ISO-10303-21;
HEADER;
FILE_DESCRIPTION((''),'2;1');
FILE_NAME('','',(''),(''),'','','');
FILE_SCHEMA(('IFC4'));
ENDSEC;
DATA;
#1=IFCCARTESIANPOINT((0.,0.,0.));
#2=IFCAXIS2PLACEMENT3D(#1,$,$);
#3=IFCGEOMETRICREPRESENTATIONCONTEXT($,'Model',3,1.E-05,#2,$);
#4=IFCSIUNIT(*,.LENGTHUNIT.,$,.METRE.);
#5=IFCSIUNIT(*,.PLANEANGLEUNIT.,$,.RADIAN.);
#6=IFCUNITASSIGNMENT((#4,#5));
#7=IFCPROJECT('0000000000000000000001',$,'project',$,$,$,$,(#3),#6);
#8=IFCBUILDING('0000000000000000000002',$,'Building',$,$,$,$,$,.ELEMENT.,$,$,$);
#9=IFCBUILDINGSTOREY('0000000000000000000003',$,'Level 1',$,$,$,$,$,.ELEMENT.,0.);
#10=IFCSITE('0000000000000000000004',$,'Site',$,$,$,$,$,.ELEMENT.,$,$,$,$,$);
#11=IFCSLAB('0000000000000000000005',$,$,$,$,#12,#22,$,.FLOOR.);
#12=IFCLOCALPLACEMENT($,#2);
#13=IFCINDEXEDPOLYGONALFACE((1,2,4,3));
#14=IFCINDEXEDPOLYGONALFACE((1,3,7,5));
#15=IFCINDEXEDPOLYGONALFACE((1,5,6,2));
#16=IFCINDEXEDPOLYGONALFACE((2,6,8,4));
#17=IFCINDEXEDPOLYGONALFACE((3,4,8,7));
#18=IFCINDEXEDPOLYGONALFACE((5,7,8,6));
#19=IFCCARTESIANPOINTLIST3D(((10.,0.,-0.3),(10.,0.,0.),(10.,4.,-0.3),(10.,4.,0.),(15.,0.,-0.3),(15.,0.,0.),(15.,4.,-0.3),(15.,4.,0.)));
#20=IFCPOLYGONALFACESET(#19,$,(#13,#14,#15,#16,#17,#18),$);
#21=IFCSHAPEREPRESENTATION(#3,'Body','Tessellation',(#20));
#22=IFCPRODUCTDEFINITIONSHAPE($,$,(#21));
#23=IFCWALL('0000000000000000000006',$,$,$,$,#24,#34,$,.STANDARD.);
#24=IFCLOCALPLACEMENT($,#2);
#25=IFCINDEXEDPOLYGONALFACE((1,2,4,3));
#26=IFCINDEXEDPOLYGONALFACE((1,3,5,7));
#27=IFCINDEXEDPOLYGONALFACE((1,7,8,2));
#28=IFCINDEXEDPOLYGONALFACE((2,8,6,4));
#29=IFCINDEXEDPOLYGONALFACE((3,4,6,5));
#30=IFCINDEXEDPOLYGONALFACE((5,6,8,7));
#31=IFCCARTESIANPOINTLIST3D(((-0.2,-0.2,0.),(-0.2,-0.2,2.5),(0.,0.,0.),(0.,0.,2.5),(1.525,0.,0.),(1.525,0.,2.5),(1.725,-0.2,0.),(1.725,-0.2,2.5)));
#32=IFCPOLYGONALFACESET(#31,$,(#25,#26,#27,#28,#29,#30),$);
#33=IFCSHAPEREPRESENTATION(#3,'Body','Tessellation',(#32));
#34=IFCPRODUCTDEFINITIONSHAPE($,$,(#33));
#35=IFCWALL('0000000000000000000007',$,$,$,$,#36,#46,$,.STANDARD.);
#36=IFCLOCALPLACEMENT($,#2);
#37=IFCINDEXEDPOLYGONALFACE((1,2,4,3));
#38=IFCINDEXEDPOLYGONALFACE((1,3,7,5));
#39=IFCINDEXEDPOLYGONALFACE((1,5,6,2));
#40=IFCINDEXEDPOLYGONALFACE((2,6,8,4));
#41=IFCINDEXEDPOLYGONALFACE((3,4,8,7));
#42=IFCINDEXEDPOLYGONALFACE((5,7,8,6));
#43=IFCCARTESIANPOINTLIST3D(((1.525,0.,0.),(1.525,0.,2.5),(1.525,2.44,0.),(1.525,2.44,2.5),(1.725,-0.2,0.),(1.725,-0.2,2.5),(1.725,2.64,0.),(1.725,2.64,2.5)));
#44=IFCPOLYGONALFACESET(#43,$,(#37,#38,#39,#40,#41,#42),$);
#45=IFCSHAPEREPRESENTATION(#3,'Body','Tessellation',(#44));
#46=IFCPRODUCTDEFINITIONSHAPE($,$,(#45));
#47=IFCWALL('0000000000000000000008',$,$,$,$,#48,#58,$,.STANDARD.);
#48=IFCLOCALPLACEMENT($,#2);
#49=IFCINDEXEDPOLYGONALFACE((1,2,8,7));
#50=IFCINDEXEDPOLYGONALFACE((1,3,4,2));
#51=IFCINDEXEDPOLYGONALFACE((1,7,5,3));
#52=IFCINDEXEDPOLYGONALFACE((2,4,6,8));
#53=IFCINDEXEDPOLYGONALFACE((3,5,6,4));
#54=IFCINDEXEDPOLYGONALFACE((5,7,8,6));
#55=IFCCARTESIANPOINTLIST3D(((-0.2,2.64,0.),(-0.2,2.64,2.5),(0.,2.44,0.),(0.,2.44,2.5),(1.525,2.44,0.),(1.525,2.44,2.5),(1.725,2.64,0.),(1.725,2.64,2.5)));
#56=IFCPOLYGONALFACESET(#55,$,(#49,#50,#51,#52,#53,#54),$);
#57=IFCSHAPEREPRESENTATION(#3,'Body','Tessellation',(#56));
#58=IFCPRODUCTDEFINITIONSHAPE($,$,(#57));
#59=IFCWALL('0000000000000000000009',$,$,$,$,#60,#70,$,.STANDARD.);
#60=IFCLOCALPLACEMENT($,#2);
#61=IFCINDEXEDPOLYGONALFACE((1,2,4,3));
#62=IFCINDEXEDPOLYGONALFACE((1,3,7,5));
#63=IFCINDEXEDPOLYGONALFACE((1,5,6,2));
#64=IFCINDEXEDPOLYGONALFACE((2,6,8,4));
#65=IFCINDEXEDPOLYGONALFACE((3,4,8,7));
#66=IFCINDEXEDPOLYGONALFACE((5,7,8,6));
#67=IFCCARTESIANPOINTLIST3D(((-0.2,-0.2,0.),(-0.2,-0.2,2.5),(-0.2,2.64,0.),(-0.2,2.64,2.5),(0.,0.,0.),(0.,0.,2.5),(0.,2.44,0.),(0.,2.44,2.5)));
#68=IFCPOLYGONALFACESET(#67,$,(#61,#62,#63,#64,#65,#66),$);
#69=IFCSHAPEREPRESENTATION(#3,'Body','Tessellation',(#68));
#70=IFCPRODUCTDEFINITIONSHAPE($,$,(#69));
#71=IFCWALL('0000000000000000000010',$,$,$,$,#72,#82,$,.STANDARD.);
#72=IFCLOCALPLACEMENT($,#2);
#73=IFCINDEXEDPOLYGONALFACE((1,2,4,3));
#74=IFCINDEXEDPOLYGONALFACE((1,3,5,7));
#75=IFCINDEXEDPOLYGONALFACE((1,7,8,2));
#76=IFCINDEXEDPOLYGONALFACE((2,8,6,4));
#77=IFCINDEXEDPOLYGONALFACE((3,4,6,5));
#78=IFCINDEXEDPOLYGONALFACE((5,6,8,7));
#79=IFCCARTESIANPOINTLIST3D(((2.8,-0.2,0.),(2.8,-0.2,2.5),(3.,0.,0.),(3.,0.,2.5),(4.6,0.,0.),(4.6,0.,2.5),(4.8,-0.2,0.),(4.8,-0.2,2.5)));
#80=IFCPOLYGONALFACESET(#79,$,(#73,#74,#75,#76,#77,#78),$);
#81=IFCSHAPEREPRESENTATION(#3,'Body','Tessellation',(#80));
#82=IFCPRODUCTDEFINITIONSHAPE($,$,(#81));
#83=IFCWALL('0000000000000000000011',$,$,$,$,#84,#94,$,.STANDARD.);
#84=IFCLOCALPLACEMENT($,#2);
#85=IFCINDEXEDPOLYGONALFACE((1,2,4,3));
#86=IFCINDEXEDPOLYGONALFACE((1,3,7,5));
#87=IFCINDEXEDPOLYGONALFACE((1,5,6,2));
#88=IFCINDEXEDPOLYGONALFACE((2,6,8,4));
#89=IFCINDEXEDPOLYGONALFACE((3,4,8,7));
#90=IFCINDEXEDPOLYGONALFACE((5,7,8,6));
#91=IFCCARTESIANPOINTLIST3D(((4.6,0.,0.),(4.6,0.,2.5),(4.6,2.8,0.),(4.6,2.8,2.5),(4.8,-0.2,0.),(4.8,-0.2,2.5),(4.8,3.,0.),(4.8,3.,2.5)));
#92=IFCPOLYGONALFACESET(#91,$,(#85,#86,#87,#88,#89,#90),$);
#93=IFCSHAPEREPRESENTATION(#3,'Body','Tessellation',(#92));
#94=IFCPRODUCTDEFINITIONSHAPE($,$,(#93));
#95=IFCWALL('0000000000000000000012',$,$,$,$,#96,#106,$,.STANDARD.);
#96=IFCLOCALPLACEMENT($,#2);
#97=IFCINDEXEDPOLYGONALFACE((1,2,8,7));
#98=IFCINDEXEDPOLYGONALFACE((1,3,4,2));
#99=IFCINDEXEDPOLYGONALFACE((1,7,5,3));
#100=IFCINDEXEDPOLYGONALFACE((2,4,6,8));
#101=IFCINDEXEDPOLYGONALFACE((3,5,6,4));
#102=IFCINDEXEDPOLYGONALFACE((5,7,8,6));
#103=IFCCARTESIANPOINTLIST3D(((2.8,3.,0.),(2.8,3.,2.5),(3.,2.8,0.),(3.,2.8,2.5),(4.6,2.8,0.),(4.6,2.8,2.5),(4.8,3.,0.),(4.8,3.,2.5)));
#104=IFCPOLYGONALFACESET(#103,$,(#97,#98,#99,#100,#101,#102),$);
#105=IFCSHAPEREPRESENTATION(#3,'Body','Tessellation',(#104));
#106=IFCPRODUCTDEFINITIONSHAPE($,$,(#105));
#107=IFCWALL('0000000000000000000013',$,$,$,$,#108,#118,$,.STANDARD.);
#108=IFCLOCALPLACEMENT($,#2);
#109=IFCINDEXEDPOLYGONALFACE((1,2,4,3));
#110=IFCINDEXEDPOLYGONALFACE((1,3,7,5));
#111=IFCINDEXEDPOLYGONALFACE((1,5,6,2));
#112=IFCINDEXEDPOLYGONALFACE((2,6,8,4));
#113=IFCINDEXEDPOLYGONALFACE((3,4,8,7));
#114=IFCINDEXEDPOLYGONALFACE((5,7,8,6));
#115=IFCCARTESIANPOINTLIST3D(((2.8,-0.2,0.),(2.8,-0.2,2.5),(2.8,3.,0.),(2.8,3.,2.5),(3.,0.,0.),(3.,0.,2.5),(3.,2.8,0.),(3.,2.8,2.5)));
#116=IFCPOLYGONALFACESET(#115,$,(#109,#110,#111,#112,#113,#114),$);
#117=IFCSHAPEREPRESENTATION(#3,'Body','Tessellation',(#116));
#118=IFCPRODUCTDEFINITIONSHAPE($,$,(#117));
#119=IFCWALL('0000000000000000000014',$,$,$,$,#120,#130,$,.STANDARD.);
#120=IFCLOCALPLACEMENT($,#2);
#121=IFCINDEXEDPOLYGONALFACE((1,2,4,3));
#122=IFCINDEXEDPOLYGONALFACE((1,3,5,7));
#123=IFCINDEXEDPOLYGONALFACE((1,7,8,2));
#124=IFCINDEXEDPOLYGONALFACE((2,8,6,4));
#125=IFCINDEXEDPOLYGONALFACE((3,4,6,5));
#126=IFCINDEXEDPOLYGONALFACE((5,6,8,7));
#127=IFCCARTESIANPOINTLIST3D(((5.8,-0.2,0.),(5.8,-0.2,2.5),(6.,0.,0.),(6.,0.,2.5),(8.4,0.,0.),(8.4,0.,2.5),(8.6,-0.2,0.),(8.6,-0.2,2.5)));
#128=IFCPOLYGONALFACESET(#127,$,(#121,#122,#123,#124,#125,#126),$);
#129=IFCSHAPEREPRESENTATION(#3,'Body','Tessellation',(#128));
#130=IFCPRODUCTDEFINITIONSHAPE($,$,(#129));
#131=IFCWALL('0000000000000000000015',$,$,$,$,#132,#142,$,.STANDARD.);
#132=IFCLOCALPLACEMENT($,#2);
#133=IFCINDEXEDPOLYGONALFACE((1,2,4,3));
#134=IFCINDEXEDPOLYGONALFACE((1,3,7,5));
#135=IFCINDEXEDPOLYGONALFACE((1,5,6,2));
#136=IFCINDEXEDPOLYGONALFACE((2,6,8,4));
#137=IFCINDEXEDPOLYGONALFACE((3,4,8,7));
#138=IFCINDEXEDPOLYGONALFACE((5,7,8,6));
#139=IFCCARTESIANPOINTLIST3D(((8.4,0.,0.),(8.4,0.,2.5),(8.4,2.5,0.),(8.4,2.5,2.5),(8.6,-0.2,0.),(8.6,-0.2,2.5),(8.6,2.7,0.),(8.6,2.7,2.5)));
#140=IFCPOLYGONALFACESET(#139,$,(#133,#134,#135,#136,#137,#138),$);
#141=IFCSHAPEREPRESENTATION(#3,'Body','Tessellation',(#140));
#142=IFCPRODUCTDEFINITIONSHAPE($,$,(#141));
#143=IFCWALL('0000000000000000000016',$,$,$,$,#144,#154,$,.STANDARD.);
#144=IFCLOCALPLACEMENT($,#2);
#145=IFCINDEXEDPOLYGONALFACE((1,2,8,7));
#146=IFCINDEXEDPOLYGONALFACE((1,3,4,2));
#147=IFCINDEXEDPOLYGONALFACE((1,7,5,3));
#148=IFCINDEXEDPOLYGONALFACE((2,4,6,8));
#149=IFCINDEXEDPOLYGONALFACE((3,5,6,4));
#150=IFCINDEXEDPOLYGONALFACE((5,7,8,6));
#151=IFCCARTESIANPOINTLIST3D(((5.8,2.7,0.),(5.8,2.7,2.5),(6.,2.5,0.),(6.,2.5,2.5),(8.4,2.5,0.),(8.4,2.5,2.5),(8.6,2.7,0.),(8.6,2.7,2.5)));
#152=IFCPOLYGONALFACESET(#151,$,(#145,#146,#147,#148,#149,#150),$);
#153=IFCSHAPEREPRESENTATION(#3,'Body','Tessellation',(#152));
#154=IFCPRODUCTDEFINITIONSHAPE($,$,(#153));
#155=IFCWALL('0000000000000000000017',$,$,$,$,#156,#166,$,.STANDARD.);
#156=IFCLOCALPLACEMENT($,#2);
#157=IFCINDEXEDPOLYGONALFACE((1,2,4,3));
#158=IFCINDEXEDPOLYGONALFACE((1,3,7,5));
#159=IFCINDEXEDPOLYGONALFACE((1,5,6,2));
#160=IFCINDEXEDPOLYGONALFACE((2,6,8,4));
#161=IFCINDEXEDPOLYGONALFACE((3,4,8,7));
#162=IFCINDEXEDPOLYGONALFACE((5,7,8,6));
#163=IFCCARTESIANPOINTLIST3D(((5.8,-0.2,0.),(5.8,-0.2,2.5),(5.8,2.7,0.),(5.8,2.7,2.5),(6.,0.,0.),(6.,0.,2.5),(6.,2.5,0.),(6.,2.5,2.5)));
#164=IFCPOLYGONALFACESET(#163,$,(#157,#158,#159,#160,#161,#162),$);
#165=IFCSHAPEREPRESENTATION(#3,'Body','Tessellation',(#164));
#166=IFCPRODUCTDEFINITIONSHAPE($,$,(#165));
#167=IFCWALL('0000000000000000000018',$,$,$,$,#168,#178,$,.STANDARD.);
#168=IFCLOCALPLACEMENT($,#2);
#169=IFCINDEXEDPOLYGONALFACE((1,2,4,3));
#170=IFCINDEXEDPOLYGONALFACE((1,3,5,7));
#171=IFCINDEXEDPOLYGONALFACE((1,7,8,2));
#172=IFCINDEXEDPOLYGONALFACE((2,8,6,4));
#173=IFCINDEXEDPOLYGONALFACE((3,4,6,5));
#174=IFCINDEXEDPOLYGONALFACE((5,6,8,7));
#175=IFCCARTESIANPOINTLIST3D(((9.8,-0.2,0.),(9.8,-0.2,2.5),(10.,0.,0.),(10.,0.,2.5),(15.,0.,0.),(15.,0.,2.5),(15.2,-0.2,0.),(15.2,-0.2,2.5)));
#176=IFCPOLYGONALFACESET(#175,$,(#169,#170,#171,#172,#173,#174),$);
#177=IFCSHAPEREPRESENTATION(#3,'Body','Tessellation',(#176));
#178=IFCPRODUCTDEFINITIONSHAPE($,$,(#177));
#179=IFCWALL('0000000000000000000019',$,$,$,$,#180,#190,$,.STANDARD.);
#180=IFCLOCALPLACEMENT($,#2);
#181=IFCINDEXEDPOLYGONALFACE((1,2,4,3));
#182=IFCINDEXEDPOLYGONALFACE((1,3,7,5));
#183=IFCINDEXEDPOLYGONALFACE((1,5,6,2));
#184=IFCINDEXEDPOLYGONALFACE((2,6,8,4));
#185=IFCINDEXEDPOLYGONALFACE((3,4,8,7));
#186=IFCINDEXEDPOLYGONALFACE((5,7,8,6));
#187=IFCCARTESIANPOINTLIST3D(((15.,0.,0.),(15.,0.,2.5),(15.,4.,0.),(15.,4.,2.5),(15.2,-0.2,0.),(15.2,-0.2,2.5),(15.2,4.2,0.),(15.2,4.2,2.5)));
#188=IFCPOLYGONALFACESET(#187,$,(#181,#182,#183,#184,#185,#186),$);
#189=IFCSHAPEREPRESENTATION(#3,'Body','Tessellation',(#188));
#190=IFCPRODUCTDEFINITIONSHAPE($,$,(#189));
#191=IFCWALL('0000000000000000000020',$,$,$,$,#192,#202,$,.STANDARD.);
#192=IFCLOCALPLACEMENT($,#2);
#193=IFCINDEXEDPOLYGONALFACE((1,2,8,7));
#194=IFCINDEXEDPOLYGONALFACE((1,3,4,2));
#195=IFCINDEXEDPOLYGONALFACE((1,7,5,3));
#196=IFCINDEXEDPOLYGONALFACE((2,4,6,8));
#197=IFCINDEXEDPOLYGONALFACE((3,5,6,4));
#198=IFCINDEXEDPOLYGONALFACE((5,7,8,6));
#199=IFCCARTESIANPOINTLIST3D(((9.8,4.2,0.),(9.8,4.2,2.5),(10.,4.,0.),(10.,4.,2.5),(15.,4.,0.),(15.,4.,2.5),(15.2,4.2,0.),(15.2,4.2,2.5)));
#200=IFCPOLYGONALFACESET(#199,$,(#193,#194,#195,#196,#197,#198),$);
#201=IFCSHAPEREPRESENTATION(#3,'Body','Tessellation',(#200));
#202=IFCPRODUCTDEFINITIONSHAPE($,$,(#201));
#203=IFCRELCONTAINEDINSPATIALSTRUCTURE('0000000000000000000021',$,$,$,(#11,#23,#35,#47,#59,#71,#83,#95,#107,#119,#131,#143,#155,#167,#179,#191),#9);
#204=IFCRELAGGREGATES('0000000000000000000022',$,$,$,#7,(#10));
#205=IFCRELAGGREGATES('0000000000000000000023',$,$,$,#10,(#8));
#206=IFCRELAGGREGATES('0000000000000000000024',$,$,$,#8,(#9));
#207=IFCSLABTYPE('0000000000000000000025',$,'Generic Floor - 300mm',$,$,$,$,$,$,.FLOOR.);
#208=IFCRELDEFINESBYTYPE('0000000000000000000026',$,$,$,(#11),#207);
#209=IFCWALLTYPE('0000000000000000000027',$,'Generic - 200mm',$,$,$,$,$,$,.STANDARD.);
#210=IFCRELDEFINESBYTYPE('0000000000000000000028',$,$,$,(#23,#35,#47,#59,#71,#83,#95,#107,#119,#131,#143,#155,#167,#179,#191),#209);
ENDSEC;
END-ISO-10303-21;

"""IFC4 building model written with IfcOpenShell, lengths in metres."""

from ifc_helpers import new_model, si_unit, frame, origin, place, context, project, spatial, polyline, outline, extrude, type_object, element, save


model = new_model("IFC4")

# Units and contexts
model_context = context("Model", 3, precision=1e-05, world=origin())
ifc_project = project(units=[si_unit("LENGTHUNIT", "METRE"), si_unit("PLANEANGLEUNIT", "RADIAN")], contexts=[model_context])

# Site, building, storey
site = spatial("IfcSite", under=ifc_project, Name="Site", CompositionType="ELEMENT")
building = spatial("IfcBuilding", under=site, Name="Building", CompositionType="ELEMENT")
storey = spatial("IfcBuildingStorey", under=building, Name="Level 1", CompositionType="ELEMENT", Elevation=0.0)

# Slab
slab_type = type_object("IfcSlabType", Name="Generic Floor - 300mm", PredefinedType="FLOOR")
slab_placement = place(None, origin())
element("IfcSlab", 1, at=slab_placement, inside=storey, type_object=slab_type, PredefinedType="FLOOR", context=model_context, shape_type="SweptSolid", body=[
    extrude(outline(polyline([(10.0, 0.0), (15.0, 0.0), (15.0, 4.0), (10.0, 4.0), (10.0, 0.0)])), origin(), (0.0, 0.0, -1.0), 0.3),
])

# Walls
wall_type_1 = type_object("IfcWallType", Name="Generic - 200mm", PredefinedType="STANDARD")
wall_1_placement = place(None, frame((-0.1, -0.1, 0.0), z_axis=(0.0, 0.0, 1.0), x_axis=(1.0, 0.0, 0.0)))
element("IfcWall", 2, at=wall_1_placement, inside=storey, type_object=wall_type_1, PredefinedType="STANDARD", context=model_context, shape_type="SweptSolid", body=[
    extrude(outline(polyline([(-0.1, -0.1), (1.825, -0.1), (1.625, 0.1), (0.1, 0.1), (-0.1, -0.1)])), origin(), (0.0, 0.0, 1.0), 2.5),
])
wall_2_placement = place(None, frame((1.625, -0.1, 0.0), z_axis=(0.0, 0.0, 1.0), x_axis=(0.0, 1.0, 0.0)))
element("IfcWall", 3, at=wall_2_placement, inside=storey, type_object=wall_type_1, PredefinedType="STANDARD", context=model_context, shape_type="SweptSolid", body=[
    extrude(outline(polyline([(-0.1, -0.1), (2.74, -0.1), (2.54, 0.1), (0.1, 0.1), (-0.1, -0.1)])), origin(), (0.0, 0.0, 1.0), 2.5),
])
wall_3_placement = place(None, frame((1.625, 2.54, 0.0), z_axis=(0.0, 0.0, 1.0), x_axis=(-1.0, 0.0, 0.0)))
element("IfcWall", 4, at=wall_3_placement, inside=storey, type_object=wall_type_1, PredefinedType="STANDARD", context=model_context, shape_type="SweptSolid", body=[
    extrude(outline(polyline([(-0.1, -0.1), (1.825, -0.1), (1.625, 0.1), (0.1, 0.1), (-0.1, -0.1)])), origin(), (0.0, 0.0, 1.0), 2.5),
])
wall_4_placement = place(None, frame((-0.1, 2.54, 0.0), z_axis=(0.0, 0.0, 1.0), x_axis=(0.0, -1.0, 0.0)))
element("IfcWall", 5, at=wall_4_placement, inside=storey, type_object=wall_type_1, PredefinedType="STANDARD", context=model_context, shape_type="SweptSolid", body=[
    extrude(outline(polyline([(-0.1, -0.1), (2.74, -0.1), (2.54, 0.1), (0.1, 0.1), (-0.1, -0.1)])), origin(), (0.0, 0.0, 1.0), 2.5),
])
wall_5_placement = place(None, frame((2.9, -0.1, 0.0), z_axis=(0.0, 0.0, 1.0), x_axis=(1.0, 0.0, 0.0)))
element("IfcWall", 6, at=wall_5_placement, inside=storey, type_object=wall_type_1, PredefinedType="STANDARD", context=model_context, shape_type="SweptSolid", body=[
    extrude(outline(polyline([(-0.1, -0.1), (1.9, -0.1), (1.7, 0.1), (0.1, 0.1), (-0.1, -0.1)])), origin(), (0.0, 0.0, 1.0), 2.5),
])
wall_6_placement = place(None, frame((4.7, -0.1, 0.0), z_axis=(0.0, 0.0, 1.0), x_axis=(0.0, 1.0, 0.0)))
element("IfcWall", 7, at=wall_6_placement, inside=storey, type_object=wall_type_1, PredefinedType="STANDARD", context=model_context, shape_type="SweptSolid", body=[
    extrude(outline(polyline([(-0.1, -0.1), (3.1, -0.1), (2.9, 0.1), (0.1, 0.1), (-0.1, -0.1)])), origin(), (0.0, 0.0, 1.0), 2.5),
])
wall_7_placement = place(None, frame((4.7, 2.9, 0.0), z_axis=(0.0, 0.0, 1.0), x_axis=(-1.0, 0.0, 0.0)))
element("IfcWall", 8, at=wall_7_placement, inside=storey, type_object=wall_type_1, PredefinedType="STANDARD", context=model_context, shape_type="SweptSolid", body=[
    extrude(outline(polyline([(-0.1, -0.1), (1.9, -0.1), (1.7, 0.1), (0.1, 0.1), (-0.1, -0.1)])), origin(), (0.0, 0.0, 1.0), 2.5),
])
wall_8_placement = place(None, frame((2.9, 2.9, 0.0), z_axis=(0.0, 0.0, 1.0), x_axis=(0.0, -1.0, 0.0)))
element("IfcWall", 9, at=wall_8_placement, inside=storey, type_object=wall_type_1, PredefinedType="STANDARD", context=model_context, shape_type="SweptSolid", body=[
    extrude(outline(polyline([(-0.1, -0.1), (3.1, -0.1), (2.9, 0.1), (0.1, 0.1), (-0.1, -0.1)])), origin(), (0.0, 0.0, 1.0), 2.5),
])
wall_9_placement = place(None, frame((5.9, -0.1, 0.0), z_axis=(0.0, 0.0, 1.0), x_axis=(1.0, 0.0, 0.0)))
element("IfcWall", 10, at=wall_9_placement, inside=storey, type_object=wall_type_1, PredefinedType="STANDARD", context=model_context, shape_type="SweptSolid", body=[
    extrude(outline(polyline([(-0.1, -0.1), (2.7, -0.1), (2.5, 0.1), (0.1, 0.1), (-0.1, -0.1)])), origin(), (0.0, 0.0, 1.0), 2.5),
])
wall_10_placement = place(None, frame((8.5, -0.1, 0.0), z_axis=(0.0, 0.0, 1.0), x_axis=(0.0, 1.0, 0.0)))
element("IfcWall", 11, at=wall_10_placement, inside=storey, type_object=wall_type_1, PredefinedType="STANDARD", context=model_context, shape_type="SweptSolid", body=[
    extrude(outline(polyline([(-0.1, -0.1), (2.8, -0.1), (2.6, 0.1), (0.1, 0.1), (-0.1, -0.1)])), origin(), (0.0, 0.0, 1.0), 2.5),
])
wall_11_placement = place(None, frame((8.5, 2.6, 0.0), z_axis=(0.0, 0.0, 1.0), x_axis=(-1.0, 0.0, 0.0)))
element("IfcWall", 12, at=wall_11_placement, inside=storey, type_object=wall_type_1, PredefinedType="STANDARD", context=model_context, shape_type="SweptSolid", body=[
    extrude(outline(polyline([(-0.1, -0.1), (2.7, -0.1), (2.5, 0.1), (0.1, 0.1), (-0.1, -0.1)])), origin(), (0.0, 0.0, 1.0), 2.5),
])
wall_12_placement = place(None, frame((5.9, 2.6, 0.0), z_axis=(0.0, 0.0, 1.0), x_axis=(0.0, -1.0, 0.0)))
element("IfcWall", 13, at=wall_12_placement, inside=storey, type_object=wall_type_1, PredefinedType="STANDARD", context=model_context, shape_type="SweptSolid", body=[
    extrude(outline(polyline([(-0.1, -0.1), (2.8, -0.1), (2.6, 0.1), (0.1, 0.1), (-0.1, -0.1)])), origin(), (0.0, 0.0, 1.0), 2.5),
])
wall_13_placement = place(None, frame((9.9, -0.1, 0.0), z_axis=(0.0, 0.0, 1.0), x_axis=(1.0, 0.0, 0.0)))
element("IfcWall", 14, at=wall_13_placement, inside=storey, type_object=wall_type_1, PredefinedType="STANDARD", context=model_context, shape_type="SweptSolid", body=[
    extrude(outline(polyline([(-0.1, -0.1), (5.3, -0.1), (5.1, 0.1), (0.1, 0.1), (-0.1, -0.1)])), origin(), (0.0, 0.0, 1.0), 2.5),
])
wall_14_placement = place(None, frame((15.1, -0.1, 0.0), z_axis=(0.0, 0.0, 1.0), x_axis=(0.0, 1.0, 0.0)))
element("IfcWall", 15, at=wall_14_placement, inside=storey, type_object=wall_type_1, PredefinedType="STANDARD", context=model_context, shape_type="SweptSolid", body=[
    extrude(outline(polyline([(-0.1, -0.1), (4.3, -0.1), (4.1, 0.1), (0.1, 0.1), (-0.1, -0.1)])), origin(), (0.0, 0.0, 1.0), 2.5),
])
wall_15_placement = place(None, frame((15.1, 4.1, 0.0), z_axis=(0.0, 0.0, 1.0), x_axis=(-1.0, 0.0, 0.0)))
element("IfcWall", 16, at=wall_15_placement, inside=storey, type_object=wall_type_1, PredefinedType="STANDARD", context=model_context, shape_type="SweptSolid", body=[
    extrude(outline(polyline([(-0.1, -0.1), (5.3, -0.1), (5.1, 0.1), (0.1, 0.1), (-0.1, -0.1)])), origin(), (0.0, 0.0, 1.0), 2.5),
])

save(model, "model.ifc")
